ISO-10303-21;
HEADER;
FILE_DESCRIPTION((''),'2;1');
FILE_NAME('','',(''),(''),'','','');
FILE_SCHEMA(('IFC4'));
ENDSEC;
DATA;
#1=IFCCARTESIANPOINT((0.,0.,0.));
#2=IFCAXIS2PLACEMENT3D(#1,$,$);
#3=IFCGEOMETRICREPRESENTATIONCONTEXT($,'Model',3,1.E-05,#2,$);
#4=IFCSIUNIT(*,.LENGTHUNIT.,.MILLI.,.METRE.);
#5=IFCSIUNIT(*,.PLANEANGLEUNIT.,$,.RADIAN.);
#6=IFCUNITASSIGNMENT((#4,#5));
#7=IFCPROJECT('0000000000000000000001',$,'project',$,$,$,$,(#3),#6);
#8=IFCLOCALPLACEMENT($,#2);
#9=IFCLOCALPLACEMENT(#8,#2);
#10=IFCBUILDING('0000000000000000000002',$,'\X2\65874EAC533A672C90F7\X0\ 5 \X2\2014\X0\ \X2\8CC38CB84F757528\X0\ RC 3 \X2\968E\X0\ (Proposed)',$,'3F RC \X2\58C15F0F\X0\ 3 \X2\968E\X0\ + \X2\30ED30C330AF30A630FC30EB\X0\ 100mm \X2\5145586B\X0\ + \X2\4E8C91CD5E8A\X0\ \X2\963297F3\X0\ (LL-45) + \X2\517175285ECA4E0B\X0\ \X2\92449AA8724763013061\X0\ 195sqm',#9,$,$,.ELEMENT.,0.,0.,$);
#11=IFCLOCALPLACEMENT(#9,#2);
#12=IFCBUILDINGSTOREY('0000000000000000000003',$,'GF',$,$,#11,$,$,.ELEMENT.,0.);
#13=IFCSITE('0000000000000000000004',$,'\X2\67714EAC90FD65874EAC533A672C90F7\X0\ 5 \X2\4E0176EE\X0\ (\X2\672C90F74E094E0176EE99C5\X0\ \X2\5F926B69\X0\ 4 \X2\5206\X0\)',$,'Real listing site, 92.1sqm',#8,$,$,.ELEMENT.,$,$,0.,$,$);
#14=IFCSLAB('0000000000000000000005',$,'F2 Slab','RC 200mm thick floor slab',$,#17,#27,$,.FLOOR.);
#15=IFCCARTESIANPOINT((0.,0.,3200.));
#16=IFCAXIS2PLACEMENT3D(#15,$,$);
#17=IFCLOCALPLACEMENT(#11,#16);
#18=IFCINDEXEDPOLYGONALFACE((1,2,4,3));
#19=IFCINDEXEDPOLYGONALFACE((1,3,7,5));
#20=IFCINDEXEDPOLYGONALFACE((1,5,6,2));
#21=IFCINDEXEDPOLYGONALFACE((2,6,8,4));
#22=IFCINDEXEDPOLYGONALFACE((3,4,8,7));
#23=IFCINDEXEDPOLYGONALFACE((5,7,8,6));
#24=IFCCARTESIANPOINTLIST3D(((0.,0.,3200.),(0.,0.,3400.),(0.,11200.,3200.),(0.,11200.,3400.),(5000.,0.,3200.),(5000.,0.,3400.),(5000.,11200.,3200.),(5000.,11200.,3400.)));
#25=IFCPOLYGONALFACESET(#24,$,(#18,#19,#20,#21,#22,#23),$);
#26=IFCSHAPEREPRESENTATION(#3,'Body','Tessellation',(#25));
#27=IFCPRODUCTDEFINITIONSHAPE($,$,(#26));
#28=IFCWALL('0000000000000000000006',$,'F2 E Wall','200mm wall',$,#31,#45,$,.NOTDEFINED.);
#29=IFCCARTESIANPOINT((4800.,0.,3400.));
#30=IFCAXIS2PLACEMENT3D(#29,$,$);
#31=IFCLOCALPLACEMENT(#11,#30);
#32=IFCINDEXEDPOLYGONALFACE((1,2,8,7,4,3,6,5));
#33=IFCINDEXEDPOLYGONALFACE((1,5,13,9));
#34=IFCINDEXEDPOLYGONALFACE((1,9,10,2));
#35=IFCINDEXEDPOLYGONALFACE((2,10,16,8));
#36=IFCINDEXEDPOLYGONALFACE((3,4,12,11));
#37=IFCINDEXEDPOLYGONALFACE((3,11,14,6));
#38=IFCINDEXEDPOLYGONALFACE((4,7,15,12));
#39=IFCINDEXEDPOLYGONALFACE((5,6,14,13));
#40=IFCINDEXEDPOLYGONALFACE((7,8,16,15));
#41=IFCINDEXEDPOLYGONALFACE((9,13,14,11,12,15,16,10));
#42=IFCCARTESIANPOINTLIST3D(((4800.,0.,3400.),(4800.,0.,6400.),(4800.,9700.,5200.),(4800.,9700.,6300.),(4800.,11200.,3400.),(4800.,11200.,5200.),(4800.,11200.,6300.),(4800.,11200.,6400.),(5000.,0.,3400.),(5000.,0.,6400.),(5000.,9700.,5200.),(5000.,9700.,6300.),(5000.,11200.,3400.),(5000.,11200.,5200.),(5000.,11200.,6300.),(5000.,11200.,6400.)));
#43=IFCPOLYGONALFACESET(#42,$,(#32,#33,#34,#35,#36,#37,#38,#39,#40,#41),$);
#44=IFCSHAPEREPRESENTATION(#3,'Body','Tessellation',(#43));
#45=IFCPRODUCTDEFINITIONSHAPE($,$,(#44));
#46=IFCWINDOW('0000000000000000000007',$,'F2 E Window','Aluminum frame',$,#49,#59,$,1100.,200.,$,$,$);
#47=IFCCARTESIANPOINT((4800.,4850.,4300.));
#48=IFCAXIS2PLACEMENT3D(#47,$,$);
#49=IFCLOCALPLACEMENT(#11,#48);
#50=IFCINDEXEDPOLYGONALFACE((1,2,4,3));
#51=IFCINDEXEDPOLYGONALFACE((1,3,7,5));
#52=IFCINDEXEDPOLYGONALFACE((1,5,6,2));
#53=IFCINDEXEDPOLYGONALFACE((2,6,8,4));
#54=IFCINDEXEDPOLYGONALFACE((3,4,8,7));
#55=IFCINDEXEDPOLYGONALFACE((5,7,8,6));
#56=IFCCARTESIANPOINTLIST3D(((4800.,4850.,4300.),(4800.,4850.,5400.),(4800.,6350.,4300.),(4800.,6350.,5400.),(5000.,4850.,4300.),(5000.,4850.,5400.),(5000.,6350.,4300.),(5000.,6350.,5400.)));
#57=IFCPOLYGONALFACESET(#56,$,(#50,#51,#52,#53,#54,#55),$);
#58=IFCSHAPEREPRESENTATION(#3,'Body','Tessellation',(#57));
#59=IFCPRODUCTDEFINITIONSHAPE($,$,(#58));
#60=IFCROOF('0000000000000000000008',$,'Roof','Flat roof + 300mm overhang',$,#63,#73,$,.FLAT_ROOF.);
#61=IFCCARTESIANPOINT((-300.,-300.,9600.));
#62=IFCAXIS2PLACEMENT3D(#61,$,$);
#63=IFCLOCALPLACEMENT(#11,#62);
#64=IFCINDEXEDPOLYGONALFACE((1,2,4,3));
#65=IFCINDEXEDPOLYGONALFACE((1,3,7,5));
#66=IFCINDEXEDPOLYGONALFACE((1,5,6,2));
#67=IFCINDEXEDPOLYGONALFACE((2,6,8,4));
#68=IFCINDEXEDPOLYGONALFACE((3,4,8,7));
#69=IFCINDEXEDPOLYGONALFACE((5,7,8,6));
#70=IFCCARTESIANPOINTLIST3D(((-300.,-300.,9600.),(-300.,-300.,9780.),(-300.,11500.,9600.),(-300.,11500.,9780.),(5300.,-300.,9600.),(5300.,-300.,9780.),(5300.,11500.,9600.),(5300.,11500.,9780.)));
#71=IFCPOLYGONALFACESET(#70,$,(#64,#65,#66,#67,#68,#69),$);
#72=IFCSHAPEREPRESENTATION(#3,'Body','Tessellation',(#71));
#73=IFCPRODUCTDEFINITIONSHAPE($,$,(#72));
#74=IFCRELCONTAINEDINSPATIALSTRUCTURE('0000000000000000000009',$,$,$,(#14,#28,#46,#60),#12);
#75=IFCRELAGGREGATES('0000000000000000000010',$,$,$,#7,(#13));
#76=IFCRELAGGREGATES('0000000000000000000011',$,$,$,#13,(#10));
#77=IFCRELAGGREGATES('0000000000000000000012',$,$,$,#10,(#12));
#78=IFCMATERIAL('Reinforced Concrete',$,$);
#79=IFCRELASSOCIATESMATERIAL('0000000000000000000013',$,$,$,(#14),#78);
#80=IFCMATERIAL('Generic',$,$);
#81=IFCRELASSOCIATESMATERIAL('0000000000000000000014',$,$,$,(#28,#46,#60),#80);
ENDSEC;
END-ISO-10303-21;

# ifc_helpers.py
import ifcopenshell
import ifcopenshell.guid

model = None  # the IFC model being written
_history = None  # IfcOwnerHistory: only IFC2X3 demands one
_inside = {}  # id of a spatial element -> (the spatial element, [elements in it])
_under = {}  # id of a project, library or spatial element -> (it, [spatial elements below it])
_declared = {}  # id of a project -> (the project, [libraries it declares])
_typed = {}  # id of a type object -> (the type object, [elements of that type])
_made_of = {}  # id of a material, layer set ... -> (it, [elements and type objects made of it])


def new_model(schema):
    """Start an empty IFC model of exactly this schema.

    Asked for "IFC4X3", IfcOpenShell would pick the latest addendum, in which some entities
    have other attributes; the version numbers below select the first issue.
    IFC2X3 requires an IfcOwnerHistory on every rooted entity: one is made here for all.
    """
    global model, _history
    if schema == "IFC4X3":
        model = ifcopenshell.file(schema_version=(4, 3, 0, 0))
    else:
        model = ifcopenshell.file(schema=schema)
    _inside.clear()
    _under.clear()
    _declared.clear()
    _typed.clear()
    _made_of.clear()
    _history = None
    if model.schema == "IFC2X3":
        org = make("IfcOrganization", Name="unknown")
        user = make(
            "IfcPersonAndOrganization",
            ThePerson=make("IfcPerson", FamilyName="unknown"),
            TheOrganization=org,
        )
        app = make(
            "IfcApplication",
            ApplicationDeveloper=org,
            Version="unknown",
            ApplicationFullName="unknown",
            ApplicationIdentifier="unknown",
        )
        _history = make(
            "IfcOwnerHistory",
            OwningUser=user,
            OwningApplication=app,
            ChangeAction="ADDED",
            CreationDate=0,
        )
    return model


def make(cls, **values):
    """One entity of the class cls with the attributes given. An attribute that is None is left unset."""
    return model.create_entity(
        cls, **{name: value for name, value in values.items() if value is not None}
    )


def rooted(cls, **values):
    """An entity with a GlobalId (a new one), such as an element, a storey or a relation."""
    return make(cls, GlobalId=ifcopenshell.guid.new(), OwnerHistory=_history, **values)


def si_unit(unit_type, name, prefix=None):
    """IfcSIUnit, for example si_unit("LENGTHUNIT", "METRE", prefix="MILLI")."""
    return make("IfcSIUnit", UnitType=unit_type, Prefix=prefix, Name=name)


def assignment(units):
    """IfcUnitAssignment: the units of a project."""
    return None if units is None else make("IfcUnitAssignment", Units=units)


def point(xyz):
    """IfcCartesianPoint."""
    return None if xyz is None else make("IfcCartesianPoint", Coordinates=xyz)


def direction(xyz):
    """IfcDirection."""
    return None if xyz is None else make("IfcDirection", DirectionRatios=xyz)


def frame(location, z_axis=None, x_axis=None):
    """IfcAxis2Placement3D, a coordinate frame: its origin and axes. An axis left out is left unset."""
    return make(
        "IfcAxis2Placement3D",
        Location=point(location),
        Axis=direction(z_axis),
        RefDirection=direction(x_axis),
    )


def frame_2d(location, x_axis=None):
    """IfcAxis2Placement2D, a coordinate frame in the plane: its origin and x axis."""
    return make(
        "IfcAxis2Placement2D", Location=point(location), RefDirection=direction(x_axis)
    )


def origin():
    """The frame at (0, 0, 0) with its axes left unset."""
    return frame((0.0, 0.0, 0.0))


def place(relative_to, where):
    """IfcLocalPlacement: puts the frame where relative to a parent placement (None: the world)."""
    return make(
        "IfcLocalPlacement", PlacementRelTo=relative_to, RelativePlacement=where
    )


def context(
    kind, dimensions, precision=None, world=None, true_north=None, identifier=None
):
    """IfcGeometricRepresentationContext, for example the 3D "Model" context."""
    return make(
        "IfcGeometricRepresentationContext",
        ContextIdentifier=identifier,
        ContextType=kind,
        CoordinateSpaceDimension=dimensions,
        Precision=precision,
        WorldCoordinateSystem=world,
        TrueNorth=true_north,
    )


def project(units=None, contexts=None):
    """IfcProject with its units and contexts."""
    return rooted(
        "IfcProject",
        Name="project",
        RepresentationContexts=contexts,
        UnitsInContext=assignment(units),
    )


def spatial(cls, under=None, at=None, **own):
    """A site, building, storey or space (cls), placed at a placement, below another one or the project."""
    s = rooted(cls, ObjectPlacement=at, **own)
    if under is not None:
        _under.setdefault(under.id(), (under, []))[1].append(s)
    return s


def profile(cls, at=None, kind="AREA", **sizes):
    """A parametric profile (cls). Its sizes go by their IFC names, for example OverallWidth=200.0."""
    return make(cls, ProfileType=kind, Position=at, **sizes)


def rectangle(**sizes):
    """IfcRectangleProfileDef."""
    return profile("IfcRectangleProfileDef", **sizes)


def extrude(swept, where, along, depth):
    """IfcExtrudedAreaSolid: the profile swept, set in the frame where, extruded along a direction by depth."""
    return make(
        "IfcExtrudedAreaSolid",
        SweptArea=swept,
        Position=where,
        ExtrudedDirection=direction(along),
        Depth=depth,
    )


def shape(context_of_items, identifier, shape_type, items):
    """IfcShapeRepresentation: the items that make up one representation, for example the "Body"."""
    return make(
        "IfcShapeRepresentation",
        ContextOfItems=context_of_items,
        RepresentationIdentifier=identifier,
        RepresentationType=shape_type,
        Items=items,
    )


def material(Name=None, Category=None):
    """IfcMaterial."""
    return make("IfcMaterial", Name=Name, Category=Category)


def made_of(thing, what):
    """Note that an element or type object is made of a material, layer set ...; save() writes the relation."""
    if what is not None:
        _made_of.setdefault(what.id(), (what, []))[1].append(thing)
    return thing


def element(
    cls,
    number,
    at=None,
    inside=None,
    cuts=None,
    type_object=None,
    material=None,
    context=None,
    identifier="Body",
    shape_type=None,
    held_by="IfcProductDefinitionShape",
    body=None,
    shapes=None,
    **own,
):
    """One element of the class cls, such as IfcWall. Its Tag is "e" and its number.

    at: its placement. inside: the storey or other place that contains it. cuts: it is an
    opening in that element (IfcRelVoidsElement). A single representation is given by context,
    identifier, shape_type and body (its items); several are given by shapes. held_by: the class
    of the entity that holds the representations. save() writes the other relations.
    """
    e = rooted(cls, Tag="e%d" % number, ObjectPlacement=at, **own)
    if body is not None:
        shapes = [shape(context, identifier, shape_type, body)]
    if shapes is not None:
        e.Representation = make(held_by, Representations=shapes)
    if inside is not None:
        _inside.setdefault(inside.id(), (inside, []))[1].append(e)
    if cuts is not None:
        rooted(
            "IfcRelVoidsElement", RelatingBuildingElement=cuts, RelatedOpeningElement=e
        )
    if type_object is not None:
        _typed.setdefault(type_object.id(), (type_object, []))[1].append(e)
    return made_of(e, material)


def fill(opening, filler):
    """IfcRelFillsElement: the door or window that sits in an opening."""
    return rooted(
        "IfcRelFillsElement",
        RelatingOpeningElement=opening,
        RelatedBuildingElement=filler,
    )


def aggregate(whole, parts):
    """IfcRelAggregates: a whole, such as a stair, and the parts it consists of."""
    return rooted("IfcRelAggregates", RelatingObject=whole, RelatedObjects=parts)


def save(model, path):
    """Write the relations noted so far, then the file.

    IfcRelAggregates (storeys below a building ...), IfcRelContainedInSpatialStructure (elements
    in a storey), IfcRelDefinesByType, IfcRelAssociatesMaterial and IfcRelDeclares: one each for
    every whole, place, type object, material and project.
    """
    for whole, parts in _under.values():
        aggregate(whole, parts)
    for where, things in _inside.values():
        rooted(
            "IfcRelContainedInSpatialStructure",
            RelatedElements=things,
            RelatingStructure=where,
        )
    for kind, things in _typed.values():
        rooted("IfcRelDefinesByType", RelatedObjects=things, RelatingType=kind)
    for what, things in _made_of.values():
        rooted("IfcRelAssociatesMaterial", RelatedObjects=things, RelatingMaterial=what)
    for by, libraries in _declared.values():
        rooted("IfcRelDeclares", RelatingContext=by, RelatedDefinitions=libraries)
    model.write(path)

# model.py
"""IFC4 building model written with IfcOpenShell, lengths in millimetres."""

from ifc_helpers import new_model, si_unit, frame, frame_2d, origin, place, context, project, spatial, rectangle, extrude, material, element, fill, save


model = new_model("IFC4")

# Units and contexts
model_context = context("Model", 3, precision=1e-05, world=origin())
ifc_project = project(units=[si_unit("LENGTHUNIT", "METRE", prefix="MILLI"), si_unit("PLANEANGLEUNIT", "RADIAN")], contexts=[model_context])

# Site, building, storey
site_placement = place(None, origin())
site = spatial("IfcSite", under=ifc_project, at=site_placement, Name="東京都文京区本郷 5 丁目 (本郷三丁目駅 徒歩 4 分)", ObjectType="Real listing site, 92.1sqm", CompositionType="ELEMENT", RefElevation=0.0)
building_placement = place(site_placement, origin())
building = spatial("IfcBuilding", under=site, at=building_placement, Name="文京区本郷 5 — 賃貸併用 RC 3 階 (Proposed)", ObjectType="3F RC 壁式 3 階 + ロックウール 100mm 充填 + 二重床 防音 (LL-45) + 共用廊下 鉄骨片持ち 195sqm", CompositionType="ELEMENT", ElevationOfRefHeight=0.0, ElevationOfTerrain=0.0)
storey_placement = place(building_placement, origin())
storey = spatial("IfcBuildingStorey", under=building, at=storey_placement, Name="GF", CompositionType="ELEMENT", Elevation=0.0)

# Slab
ifc_material_1 = material(Name="Reinforced Concrete")
slab_1_placement = place(storey_placement, frame((0.0, 0.0, 3200.0)))
element("IfcSlab", 1, at=slab_1_placement, inside=storey, material=ifc_material_1, Name="F2 Slab", Description="RC 200mm thick floor slab", PredefinedType="FLOOR", context=model_context, shape_type="SweptSolid", body=[
    extrude(rectangle(XDim=5000.0, YDim=11200.0, at=frame_2d((2500.0, 5600.0))), frame((0.0, 0.0, 3200.0)), (0.0, 0.0, 1.0), 200.0),
])

# Shared definitions
ifc_material_2 = material(Name="Generic")

# Wall, opening, window
wall_1_placement = place(storey_placement, frame((4800.0, 0.0, 3400.0)))
wall_1 = element("IfcWall", 2, at=wall_1_placement, inside=storey, material=ifc_material_2, Name="F2 E Wall", Description="200mm wall", PredefinedType="NOTDEFINED", context=model_context, shape_type="SweptSolid", body=[
    extrude(rectangle(XDim=200.0, YDim=11200.0, at=frame_2d((100.0, 5600.0))), frame((4800.0, 0.0, 3400.0)), (0.0, 0.0, 1.0), 3000.0),
])
opening_1_placement = place(storey_placement, frame((4800.0, 4850.0, 4300.0)))
opening_1 = element("IfcOpeningElement", 3, at=opening_1_placement, cuts=wall_1, PredefinedType="NOTDEFINED", context=model_context, shape_type="SweptSolid", body=[
    extrude(rectangle(XDim=200.0, YDim=1500.0, at=frame_2d((100.0, 750.0))), frame((4800.0, 4850.0, 4300.0)), (0.0, 0.0, 1.0), 1100.0),
])
window_1_placement = place(storey_placement, frame((4800.0, 4850.0, 4300.0)))
window_1 = element("IfcWindow", 4, at=window_1_placement, inside=storey, material=ifc_material_2, Name="F2 E Window", Description="Aluminum frame", OverallHeight=1100.0, OverallWidth=200.0, context=model_context, shape_type="SweptSolid", body=[
    extrude(rectangle(XDim=200.0, YDim=1500.0, at=frame_2d((100.0, 750.0))), frame((4800.0, 4850.0, 4300.0)), (0.0, 0.0, 1.0), 1100.0),
])
fill(opening_1, window_1)

# Roof
roof_placement = place(storey_placement, frame((-300.0, -300.0, 9600.0)))
element("IfcRoof", 5, at=roof_placement, inside=storey, material=ifc_material_2, Name="Roof", Description="Flat roof + 300mm overhang", PredefinedType="FLAT_ROOF", context=model_context, shape_type="SweptSolid", body=[
    extrude(rectangle(XDim=5600.0, YDim=11800.0, at=frame_2d((2800.0, 5900.0))), frame((-300.0, -300.0, 9600.0)), (0.0, 0.0, 1.0), 180.0),
])

save(model, "model.ifc")
